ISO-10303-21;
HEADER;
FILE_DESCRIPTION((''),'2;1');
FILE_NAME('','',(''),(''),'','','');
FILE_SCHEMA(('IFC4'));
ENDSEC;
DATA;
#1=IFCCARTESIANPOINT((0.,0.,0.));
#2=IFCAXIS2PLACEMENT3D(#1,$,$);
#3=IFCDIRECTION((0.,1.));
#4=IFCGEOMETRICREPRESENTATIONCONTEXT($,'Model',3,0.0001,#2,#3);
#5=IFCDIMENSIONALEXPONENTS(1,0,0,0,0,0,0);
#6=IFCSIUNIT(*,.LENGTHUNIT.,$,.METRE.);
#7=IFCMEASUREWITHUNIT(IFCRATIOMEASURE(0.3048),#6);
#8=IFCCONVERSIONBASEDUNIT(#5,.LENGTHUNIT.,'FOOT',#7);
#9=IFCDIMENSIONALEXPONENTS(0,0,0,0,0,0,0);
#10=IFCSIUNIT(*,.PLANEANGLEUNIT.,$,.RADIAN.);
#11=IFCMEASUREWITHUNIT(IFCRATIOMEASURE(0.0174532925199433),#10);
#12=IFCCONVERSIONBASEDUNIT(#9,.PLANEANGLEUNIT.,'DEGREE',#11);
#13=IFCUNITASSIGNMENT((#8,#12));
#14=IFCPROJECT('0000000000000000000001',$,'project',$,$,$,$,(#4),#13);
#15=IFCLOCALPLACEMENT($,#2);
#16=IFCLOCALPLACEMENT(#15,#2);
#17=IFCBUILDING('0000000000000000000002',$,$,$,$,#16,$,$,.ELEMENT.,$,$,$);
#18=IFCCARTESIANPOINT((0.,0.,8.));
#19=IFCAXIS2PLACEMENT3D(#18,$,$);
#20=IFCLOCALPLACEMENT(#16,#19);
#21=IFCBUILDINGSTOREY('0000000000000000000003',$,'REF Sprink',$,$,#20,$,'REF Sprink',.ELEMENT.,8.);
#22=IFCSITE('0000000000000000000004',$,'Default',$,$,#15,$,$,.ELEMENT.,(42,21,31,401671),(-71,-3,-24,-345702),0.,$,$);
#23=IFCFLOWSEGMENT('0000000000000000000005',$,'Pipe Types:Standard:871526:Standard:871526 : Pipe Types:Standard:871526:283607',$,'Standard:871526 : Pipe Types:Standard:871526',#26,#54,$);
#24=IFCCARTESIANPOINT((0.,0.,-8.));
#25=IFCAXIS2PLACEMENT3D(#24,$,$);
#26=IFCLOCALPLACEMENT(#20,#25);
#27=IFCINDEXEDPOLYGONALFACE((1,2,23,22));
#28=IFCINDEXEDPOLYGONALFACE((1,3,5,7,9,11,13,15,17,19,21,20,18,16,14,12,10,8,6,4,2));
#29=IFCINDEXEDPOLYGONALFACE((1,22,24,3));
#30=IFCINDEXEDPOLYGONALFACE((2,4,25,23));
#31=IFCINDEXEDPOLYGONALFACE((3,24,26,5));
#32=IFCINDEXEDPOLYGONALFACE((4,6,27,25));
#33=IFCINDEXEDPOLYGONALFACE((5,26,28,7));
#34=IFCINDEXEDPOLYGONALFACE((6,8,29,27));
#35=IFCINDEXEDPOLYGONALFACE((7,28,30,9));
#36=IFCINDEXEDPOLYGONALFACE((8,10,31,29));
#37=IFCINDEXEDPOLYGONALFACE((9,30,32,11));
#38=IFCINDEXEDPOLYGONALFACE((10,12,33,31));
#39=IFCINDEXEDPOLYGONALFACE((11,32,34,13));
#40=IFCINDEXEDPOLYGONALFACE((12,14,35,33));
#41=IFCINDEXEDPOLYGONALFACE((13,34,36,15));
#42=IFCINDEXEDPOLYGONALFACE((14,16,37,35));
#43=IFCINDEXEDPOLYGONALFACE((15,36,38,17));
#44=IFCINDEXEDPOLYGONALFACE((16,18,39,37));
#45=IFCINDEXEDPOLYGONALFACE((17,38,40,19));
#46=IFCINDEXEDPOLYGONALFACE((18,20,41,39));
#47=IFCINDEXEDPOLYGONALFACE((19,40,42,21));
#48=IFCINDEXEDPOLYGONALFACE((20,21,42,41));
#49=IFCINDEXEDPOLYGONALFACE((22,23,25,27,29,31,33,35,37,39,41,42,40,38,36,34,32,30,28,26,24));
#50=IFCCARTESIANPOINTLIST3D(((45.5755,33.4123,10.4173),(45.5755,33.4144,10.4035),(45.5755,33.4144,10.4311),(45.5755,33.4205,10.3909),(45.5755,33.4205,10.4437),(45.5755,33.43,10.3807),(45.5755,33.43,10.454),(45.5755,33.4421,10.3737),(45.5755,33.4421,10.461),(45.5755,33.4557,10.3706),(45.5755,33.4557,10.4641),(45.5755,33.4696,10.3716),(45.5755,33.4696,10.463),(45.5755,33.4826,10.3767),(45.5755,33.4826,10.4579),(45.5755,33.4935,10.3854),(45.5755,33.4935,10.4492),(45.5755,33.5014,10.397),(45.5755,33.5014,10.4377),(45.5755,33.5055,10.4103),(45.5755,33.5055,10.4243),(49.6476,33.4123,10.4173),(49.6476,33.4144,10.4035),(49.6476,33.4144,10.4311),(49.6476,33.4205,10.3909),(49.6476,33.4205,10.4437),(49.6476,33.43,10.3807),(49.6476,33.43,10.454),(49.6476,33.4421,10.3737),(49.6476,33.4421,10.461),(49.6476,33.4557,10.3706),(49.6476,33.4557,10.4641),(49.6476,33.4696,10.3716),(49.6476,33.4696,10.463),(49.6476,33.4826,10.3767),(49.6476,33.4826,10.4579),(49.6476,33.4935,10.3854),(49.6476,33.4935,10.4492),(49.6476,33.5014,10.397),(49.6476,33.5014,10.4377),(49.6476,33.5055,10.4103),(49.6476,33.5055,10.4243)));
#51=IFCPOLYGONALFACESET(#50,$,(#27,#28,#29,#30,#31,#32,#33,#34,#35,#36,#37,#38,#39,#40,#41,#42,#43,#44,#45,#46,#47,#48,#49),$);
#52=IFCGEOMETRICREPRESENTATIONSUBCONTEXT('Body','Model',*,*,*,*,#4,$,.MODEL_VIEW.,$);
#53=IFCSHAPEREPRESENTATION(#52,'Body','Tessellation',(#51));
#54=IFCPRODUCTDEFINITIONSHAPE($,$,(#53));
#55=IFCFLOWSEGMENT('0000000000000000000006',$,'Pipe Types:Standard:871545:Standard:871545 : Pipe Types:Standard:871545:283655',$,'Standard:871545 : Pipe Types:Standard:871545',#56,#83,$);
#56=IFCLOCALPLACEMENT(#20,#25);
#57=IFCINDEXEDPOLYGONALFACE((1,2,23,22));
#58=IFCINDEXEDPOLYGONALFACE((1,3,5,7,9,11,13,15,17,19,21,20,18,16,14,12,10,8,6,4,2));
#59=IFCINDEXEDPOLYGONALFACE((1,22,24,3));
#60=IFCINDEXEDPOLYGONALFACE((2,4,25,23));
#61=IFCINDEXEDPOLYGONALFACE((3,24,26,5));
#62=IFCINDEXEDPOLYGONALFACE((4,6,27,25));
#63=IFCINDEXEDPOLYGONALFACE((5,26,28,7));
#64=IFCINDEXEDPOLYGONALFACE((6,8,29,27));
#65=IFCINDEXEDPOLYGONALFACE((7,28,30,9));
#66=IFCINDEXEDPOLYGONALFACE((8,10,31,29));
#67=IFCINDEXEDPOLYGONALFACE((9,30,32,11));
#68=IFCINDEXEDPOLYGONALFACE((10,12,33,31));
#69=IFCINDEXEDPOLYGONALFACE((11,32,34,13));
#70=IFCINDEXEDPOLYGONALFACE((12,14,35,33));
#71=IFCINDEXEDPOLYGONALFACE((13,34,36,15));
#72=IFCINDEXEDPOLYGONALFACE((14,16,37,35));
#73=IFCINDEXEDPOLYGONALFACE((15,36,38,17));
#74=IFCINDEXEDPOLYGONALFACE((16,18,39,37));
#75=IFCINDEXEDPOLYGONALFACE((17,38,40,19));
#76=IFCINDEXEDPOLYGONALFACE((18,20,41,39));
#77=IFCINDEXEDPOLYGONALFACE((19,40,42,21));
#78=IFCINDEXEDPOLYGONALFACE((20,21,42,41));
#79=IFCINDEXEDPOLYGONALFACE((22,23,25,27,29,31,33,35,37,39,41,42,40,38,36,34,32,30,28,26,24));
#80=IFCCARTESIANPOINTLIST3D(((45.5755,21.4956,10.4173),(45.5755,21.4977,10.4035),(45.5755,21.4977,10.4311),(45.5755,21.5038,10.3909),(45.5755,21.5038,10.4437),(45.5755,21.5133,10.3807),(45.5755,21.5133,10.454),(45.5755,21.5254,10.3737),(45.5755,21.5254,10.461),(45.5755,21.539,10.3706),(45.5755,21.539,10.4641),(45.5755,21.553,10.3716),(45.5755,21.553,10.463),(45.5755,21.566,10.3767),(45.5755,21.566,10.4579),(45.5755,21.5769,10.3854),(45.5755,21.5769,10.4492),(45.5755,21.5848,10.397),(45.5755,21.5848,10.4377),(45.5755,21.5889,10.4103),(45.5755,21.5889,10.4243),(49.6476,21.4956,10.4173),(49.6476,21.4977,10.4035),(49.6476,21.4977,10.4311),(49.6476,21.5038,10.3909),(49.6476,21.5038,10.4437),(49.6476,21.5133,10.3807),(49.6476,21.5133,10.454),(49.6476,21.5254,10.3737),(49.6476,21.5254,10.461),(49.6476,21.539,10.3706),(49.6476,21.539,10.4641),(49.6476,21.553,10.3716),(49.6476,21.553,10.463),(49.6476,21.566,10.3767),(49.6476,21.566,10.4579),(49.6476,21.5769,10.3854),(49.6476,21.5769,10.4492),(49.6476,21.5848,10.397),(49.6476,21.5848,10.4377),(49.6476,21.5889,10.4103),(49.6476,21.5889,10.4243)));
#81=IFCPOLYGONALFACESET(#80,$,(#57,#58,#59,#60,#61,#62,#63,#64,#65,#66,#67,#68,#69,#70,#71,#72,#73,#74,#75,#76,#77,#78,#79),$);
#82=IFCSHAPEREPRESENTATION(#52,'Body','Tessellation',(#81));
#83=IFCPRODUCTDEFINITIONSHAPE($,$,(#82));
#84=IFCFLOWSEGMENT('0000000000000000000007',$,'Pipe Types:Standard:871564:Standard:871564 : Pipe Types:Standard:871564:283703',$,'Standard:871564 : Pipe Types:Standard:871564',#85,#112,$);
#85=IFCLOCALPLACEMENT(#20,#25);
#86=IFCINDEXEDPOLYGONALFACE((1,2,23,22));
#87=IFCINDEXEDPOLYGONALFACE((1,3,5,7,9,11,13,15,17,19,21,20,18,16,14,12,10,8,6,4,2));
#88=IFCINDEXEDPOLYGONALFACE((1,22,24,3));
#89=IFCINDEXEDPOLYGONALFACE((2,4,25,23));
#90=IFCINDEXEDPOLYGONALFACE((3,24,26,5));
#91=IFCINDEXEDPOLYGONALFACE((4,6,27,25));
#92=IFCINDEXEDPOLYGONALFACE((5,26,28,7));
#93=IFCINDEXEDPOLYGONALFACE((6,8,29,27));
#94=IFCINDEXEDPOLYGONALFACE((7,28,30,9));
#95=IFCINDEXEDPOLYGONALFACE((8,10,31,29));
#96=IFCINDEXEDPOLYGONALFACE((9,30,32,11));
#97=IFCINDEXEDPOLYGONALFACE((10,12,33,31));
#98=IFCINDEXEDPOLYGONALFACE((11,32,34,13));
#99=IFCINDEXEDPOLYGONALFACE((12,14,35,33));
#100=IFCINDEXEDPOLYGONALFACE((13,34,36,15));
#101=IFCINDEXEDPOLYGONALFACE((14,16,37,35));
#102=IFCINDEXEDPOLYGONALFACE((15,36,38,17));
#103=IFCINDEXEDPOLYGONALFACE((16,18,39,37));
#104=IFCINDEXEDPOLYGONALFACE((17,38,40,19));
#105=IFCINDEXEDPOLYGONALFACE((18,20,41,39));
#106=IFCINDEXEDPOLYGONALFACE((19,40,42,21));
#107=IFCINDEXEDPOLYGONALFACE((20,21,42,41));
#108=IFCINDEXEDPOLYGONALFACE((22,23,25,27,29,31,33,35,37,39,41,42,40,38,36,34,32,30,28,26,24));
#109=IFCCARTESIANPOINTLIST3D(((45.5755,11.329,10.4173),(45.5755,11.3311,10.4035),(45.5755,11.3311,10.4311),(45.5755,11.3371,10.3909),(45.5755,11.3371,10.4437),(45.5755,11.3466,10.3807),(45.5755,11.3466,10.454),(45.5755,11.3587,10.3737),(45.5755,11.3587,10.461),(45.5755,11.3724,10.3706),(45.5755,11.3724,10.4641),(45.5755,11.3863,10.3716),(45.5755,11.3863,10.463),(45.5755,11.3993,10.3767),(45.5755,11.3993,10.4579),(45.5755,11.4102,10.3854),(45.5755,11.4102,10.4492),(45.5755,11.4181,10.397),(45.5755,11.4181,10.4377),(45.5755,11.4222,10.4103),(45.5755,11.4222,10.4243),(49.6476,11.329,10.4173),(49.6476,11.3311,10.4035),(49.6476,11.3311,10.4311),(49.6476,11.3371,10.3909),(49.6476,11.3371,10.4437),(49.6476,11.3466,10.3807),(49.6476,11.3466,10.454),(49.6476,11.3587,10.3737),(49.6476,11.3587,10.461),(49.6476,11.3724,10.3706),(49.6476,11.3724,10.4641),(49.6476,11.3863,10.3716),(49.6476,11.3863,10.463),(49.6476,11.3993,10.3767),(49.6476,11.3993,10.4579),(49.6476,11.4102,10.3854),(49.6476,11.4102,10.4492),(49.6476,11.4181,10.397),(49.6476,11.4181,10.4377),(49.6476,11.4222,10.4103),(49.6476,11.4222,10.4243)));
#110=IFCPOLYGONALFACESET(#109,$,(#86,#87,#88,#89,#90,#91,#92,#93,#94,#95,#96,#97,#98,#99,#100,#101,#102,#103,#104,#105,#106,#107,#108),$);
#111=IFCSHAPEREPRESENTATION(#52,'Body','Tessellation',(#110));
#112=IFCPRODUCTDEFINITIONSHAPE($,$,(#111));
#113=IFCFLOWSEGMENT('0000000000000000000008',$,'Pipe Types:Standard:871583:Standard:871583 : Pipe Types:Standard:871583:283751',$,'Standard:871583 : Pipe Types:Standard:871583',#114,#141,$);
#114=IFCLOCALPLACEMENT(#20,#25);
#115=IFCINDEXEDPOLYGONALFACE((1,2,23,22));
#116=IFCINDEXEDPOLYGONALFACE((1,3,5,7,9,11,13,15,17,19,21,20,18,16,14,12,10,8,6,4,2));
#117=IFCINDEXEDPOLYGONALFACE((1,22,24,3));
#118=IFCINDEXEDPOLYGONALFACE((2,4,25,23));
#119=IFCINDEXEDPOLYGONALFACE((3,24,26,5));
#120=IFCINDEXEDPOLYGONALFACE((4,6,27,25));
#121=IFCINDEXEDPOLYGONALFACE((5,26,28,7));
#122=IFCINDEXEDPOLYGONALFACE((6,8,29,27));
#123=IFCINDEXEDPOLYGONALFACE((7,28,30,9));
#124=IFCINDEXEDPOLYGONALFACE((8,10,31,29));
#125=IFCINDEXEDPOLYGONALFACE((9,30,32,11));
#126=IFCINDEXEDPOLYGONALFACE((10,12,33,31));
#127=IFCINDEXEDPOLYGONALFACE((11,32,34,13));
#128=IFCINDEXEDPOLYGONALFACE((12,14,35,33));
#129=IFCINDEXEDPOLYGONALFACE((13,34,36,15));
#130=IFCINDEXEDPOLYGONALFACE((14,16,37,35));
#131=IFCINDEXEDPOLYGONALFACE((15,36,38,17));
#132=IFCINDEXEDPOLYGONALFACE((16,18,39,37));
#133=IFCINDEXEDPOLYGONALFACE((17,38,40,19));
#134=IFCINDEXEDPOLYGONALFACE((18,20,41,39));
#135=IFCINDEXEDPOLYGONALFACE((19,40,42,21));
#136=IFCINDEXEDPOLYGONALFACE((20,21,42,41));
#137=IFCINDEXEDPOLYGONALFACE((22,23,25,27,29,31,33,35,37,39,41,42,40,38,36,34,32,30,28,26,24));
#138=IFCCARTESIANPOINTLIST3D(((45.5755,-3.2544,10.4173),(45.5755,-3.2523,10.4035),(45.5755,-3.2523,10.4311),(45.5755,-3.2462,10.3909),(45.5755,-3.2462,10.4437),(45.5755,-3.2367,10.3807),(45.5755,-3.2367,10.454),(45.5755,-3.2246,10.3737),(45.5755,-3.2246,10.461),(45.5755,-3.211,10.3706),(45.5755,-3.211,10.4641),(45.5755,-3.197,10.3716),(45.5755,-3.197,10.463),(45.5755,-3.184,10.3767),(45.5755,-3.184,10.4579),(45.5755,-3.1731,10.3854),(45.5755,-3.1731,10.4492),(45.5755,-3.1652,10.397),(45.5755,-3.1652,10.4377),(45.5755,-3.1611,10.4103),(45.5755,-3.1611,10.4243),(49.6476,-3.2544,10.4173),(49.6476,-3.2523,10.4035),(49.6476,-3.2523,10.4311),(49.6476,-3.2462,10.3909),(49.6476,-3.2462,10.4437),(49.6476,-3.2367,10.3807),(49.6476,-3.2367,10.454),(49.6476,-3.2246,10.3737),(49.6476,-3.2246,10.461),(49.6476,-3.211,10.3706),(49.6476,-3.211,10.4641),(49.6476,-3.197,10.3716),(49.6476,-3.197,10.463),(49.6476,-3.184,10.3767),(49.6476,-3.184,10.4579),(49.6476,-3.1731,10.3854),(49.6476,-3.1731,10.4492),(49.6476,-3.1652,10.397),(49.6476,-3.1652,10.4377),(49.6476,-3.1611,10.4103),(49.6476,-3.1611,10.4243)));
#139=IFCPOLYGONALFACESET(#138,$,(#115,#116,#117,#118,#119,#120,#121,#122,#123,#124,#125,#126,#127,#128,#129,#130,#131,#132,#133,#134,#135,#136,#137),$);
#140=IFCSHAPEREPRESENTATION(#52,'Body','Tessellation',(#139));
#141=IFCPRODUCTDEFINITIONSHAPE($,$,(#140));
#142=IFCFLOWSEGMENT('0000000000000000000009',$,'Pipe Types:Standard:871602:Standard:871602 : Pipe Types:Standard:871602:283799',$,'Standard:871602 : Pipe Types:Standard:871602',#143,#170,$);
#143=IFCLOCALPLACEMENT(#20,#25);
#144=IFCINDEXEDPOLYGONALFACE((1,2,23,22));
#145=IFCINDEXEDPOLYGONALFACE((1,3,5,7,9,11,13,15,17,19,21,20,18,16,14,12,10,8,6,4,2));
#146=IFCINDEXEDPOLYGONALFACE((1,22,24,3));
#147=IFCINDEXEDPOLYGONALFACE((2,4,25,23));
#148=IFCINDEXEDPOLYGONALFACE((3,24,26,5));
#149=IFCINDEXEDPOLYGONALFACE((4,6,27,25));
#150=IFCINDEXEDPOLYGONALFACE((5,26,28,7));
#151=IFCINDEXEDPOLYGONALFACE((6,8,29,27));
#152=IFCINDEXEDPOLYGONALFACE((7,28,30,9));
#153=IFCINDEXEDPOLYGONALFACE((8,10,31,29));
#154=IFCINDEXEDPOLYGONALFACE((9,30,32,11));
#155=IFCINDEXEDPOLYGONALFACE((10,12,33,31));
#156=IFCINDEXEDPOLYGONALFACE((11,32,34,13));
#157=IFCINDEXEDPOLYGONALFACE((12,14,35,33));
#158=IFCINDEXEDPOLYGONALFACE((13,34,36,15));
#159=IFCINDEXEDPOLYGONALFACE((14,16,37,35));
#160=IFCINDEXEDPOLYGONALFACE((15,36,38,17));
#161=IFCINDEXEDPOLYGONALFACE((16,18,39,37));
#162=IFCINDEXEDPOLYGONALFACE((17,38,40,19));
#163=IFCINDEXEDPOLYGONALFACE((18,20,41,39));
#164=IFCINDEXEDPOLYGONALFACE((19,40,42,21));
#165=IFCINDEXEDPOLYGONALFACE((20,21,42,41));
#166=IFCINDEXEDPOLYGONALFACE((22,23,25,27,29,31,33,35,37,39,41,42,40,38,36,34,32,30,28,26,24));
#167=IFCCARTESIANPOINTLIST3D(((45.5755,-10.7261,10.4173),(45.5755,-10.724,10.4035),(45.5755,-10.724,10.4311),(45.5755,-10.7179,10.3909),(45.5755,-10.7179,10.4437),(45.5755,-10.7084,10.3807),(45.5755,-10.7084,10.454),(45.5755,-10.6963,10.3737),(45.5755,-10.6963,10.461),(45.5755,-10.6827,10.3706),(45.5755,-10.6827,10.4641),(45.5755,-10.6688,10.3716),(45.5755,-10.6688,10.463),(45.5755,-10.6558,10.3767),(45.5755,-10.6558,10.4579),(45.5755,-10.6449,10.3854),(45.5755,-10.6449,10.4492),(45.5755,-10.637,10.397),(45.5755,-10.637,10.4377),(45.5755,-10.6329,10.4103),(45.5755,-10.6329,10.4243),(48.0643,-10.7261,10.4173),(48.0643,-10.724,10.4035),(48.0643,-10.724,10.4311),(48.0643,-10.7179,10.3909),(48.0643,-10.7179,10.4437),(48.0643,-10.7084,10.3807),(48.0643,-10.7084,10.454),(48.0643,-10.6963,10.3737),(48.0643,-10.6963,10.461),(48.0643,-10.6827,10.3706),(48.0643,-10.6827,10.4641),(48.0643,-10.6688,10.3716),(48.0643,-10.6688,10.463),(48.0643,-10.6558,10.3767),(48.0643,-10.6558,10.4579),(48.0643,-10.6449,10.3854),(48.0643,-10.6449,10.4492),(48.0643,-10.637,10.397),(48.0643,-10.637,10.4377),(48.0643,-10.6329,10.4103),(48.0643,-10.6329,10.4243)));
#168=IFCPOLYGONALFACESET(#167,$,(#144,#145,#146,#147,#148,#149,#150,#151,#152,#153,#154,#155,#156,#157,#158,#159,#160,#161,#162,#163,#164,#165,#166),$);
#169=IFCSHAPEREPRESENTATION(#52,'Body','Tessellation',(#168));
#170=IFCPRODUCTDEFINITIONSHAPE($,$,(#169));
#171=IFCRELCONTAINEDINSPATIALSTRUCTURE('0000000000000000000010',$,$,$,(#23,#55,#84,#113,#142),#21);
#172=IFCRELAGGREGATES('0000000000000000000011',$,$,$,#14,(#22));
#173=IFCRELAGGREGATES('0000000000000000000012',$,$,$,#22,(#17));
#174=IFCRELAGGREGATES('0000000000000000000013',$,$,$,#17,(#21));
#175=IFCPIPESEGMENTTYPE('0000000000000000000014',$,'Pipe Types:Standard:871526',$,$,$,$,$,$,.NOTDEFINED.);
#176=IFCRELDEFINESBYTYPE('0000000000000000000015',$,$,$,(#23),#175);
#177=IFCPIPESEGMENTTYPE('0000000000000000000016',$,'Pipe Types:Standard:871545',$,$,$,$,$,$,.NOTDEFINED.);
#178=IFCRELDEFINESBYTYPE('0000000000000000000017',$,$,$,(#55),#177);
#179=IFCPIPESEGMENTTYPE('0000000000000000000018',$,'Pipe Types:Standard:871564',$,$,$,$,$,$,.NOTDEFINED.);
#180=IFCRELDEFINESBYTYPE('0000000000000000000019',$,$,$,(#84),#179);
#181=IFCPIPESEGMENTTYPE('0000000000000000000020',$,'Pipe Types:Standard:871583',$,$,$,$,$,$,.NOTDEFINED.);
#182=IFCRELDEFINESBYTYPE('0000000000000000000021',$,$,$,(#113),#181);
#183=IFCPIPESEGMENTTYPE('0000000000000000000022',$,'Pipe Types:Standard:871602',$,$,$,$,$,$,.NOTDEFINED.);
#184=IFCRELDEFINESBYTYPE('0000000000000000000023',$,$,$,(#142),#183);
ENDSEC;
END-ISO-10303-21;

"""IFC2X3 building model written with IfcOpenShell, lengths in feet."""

from ifc_helpers import new_model, entity, si_unit, converted_unit, direction, frame, origin, origin_2d_with_axis, place, context, subcontext, project, spatial, circle, extrude, source, transform, mapped, type_object, type_shapes, element, save


model = new_model("IFC2X3")

# Units and contexts
model_context = context("Model", 3, precision=0.0001, world=origin(), true_north=direction((0.0, 1.0)))
body_context = subcontext(model_context, "Body", "Model", "MODEL_VIEW")
ifc_project = project(units=[converted_unit("LENGTHUNIT", "FOOT", entity("IfcRatioMeasure", 0.3048), si_unit("LENGTHUNIT", "METRE"), dimensions=[1, 0, 0, 0, 0, 0, 0]), converted_unit("PLANEANGLEUNIT", "DEGREE", entity("IfcRatioMeasure", 0.0174532925199433), si_unit("PLANEANGLEUNIT", "RADIAN"), dimensions=[0, 0, 0, 0, 0, 0, 0])], contexts=[model_context])

# Site, building, storey
site_placement = place(None, origin())
site = spatial("IfcSite", under=ifc_project, at=site_placement, Name="Default", CompositionType="ELEMENT", RefLatitude=(42, 21, 31, 401671), RefLongitude=(-71, -3, -24, -345702), RefElevation=0.0)
building_placement = place(site_placement, origin())
building = spatial("IfcBuilding", under=site, at=building_placement, CompositionType="ELEMENT")
storey_placement = place(building_placement, frame((0.0, 0.0, 8.0)))
storey = spatial("IfcBuildingStorey", under=building, at=storey_placement, Name="REF Sprink", LongName="REF Sprink", CompositionType="ELEMENT", Elevation=8.0)

# Flow segments
pipe_segment_type_1 = type_object("IfcPipeSegmentType", Name="Pipe Types:Standard:871526", PredefinedType="NOTDEFINED")
shared_shape_1 = source(origin(), body_context, "Body", "SweptSolid", [
    extrude(circle(Radius=0.0469, at=origin_2d_with_axis()), frame((45.5755, 33.4592, 10.4173), z_axis=(1.0, 0.0, 0.0), x_axis=(0.0, -1.0, 0.0)), (0.0, 0.0, 1.0), 4.0722),
])
type_shapes(pipe_segment_type_1, [shared_shape_1])
flow_segment_1_placement = place(storey_placement, frame((0.0, 0.0, -8.0)))
element("IfcFlowSegment", 1, at=flow_segment_1_placement, inside=storey, type_object=pipe_segment_type_1, Name="Pipe Types:Standard:871526:Standard:871526 : Pipe Types:Standard:871526:283607", ObjectType="Standard:871526 : Pipe Types:Standard:871526", context=body_context, shape_type="MappedRepresentation", body=[
    mapped(shared_shape_1, transform((0.0, 0.0, 0.0), scale=1.0)),
])
pipe_segment_type_2 = type_object("IfcPipeSegmentType", Name="Pipe Types:Standard:871545", PredefinedType="NOTDEFINED")
shared_shape_2 = source(origin(), body_context, "Body", "SweptSolid", [
    extrude(circle(Radius=0.0469, at=origin_2d_with_axis()), frame((45.5755, 21.5425, 10.4173), z_axis=(1.0, 0.0, 0.0), x_axis=(0.0, -1.0, 0.0)), (0.0, 0.0, 1.0), 4.0722),
])
type_shapes(pipe_segment_type_2, [shared_shape_2])
flow_segment_2_placement = place(storey_placement, frame((0.0, 0.0, -8.0)))
element("IfcFlowSegment", 2, at=flow_segment_2_placement, inside=storey, type_object=pipe_segment_type_2, Name="Pipe Types:Standard:871545:Standard:871545 : Pipe Types:Standard:871545:283655", ObjectType="Standard:871545 : Pipe Types:Standard:871545", context=body_context, shape_type="MappedRepresentation", body=[
    mapped(shared_shape_2, transform((0.0, 0.0, 0.0), scale=1.0)),
])
pipe_segment_type_3 = type_object("IfcPipeSegmentType", Name="Pipe Types:Standard:871564", PredefinedType="NOTDEFINED")
shared_shape_3 = source(origin(), body_context, "Body", "SweptSolid", [
    extrude(circle(Radius=0.0469, at=origin_2d_with_axis()), frame((45.5755, 11.3759, 10.4173), z_axis=(1.0, 0.0, 0.0), x_axis=(0.0, -1.0, 0.0)), (0.0, 0.0, 1.0), 4.0722),
])
type_shapes(pipe_segment_type_3, [shared_shape_3])
flow_segment_3_placement = place(storey_placement, frame((0.0, 0.0, -8.0)))
element("IfcFlowSegment", 3, at=flow_segment_3_placement, inside=storey, type_object=pipe_segment_type_3, Name="Pipe Types:Standard:871564:Standard:871564 : Pipe Types:Standard:871564:283703", ObjectType="Standard:871564 : Pipe Types:Standard:871564", context=body_context, shape_type="MappedRepresentation", body=[
    mapped(shared_shape_3, transform((0.0, 0.0, 0.0), scale=1.0)),
])
pipe_segment_type_4 = type_object("IfcPipeSegmentType", Name="Pipe Types:Standard:871583", PredefinedType="NOTDEFINED")
shared_shape_4 = source(origin(), body_context, "Body", "SweptSolid", [
    extrude(circle(Radius=0.0469, at=origin_2d_with_axis()), frame((45.5755, -3.2075, 10.4173), z_axis=(1.0, 0.0, 0.0), x_axis=(0.0, -1.0, 0.0)), (0.0, 0.0, 1.0), 4.0722),
])
type_shapes(pipe_segment_type_4, [shared_shape_4])
flow_segment_4_placement = place(storey_placement, frame((0.0, 0.0, -8.0)))
element("IfcFlowSegment", 4, at=flow_segment_4_placement, inside=storey, type_object=pipe_segment_type_4, Name="Pipe Types:Standard:871583:Standard:871583 : Pipe Types:Standard:871583:283751", ObjectType="Standard:871583 : Pipe Types:Standard:871583", context=body_context, shape_type="MappedRepresentation", body=[
    mapped(shared_shape_4, transform((0.0, 0.0, 0.0), scale=1.0)),
])
pipe_segment_type_5 = type_object("IfcPipeSegmentType", Name="Pipe Types:Standard:871602", PredefinedType="NOTDEFINED")
shared_shape_5 = source(origin(), body_context, "Body", "SweptSolid", [
    extrude(circle(Radius=0.0469, at=origin_2d_with_axis()), frame((45.5755, -10.6792, 10.4173), z_axis=(1.0, 0.0, 0.0), x_axis=(0.0, -1.0, 0.0)), (0.0, 0.0, 1.0), 2.4888),
])
type_shapes(pipe_segment_type_5, [shared_shape_5])
flow_segment_5_placement = place(storey_placement, frame((0.0, 0.0, -8.0)))
element("IfcFlowSegment", 5, at=flow_segment_5_placement, inside=storey, type_object=pipe_segment_type_5, Name="Pipe Types:Standard:871602:Standard:871602 : Pipe Types:Standard:871602:283799", ObjectType="Standard:871602 : Pipe Types:Standard:871602", context=body_context, shape_type="MappedRepresentation", body=[
    mapped(shared_shape_5, transform((0.0, 0.0, 0.0), scale=1.0)),
])

save(model, "model.ifc")
